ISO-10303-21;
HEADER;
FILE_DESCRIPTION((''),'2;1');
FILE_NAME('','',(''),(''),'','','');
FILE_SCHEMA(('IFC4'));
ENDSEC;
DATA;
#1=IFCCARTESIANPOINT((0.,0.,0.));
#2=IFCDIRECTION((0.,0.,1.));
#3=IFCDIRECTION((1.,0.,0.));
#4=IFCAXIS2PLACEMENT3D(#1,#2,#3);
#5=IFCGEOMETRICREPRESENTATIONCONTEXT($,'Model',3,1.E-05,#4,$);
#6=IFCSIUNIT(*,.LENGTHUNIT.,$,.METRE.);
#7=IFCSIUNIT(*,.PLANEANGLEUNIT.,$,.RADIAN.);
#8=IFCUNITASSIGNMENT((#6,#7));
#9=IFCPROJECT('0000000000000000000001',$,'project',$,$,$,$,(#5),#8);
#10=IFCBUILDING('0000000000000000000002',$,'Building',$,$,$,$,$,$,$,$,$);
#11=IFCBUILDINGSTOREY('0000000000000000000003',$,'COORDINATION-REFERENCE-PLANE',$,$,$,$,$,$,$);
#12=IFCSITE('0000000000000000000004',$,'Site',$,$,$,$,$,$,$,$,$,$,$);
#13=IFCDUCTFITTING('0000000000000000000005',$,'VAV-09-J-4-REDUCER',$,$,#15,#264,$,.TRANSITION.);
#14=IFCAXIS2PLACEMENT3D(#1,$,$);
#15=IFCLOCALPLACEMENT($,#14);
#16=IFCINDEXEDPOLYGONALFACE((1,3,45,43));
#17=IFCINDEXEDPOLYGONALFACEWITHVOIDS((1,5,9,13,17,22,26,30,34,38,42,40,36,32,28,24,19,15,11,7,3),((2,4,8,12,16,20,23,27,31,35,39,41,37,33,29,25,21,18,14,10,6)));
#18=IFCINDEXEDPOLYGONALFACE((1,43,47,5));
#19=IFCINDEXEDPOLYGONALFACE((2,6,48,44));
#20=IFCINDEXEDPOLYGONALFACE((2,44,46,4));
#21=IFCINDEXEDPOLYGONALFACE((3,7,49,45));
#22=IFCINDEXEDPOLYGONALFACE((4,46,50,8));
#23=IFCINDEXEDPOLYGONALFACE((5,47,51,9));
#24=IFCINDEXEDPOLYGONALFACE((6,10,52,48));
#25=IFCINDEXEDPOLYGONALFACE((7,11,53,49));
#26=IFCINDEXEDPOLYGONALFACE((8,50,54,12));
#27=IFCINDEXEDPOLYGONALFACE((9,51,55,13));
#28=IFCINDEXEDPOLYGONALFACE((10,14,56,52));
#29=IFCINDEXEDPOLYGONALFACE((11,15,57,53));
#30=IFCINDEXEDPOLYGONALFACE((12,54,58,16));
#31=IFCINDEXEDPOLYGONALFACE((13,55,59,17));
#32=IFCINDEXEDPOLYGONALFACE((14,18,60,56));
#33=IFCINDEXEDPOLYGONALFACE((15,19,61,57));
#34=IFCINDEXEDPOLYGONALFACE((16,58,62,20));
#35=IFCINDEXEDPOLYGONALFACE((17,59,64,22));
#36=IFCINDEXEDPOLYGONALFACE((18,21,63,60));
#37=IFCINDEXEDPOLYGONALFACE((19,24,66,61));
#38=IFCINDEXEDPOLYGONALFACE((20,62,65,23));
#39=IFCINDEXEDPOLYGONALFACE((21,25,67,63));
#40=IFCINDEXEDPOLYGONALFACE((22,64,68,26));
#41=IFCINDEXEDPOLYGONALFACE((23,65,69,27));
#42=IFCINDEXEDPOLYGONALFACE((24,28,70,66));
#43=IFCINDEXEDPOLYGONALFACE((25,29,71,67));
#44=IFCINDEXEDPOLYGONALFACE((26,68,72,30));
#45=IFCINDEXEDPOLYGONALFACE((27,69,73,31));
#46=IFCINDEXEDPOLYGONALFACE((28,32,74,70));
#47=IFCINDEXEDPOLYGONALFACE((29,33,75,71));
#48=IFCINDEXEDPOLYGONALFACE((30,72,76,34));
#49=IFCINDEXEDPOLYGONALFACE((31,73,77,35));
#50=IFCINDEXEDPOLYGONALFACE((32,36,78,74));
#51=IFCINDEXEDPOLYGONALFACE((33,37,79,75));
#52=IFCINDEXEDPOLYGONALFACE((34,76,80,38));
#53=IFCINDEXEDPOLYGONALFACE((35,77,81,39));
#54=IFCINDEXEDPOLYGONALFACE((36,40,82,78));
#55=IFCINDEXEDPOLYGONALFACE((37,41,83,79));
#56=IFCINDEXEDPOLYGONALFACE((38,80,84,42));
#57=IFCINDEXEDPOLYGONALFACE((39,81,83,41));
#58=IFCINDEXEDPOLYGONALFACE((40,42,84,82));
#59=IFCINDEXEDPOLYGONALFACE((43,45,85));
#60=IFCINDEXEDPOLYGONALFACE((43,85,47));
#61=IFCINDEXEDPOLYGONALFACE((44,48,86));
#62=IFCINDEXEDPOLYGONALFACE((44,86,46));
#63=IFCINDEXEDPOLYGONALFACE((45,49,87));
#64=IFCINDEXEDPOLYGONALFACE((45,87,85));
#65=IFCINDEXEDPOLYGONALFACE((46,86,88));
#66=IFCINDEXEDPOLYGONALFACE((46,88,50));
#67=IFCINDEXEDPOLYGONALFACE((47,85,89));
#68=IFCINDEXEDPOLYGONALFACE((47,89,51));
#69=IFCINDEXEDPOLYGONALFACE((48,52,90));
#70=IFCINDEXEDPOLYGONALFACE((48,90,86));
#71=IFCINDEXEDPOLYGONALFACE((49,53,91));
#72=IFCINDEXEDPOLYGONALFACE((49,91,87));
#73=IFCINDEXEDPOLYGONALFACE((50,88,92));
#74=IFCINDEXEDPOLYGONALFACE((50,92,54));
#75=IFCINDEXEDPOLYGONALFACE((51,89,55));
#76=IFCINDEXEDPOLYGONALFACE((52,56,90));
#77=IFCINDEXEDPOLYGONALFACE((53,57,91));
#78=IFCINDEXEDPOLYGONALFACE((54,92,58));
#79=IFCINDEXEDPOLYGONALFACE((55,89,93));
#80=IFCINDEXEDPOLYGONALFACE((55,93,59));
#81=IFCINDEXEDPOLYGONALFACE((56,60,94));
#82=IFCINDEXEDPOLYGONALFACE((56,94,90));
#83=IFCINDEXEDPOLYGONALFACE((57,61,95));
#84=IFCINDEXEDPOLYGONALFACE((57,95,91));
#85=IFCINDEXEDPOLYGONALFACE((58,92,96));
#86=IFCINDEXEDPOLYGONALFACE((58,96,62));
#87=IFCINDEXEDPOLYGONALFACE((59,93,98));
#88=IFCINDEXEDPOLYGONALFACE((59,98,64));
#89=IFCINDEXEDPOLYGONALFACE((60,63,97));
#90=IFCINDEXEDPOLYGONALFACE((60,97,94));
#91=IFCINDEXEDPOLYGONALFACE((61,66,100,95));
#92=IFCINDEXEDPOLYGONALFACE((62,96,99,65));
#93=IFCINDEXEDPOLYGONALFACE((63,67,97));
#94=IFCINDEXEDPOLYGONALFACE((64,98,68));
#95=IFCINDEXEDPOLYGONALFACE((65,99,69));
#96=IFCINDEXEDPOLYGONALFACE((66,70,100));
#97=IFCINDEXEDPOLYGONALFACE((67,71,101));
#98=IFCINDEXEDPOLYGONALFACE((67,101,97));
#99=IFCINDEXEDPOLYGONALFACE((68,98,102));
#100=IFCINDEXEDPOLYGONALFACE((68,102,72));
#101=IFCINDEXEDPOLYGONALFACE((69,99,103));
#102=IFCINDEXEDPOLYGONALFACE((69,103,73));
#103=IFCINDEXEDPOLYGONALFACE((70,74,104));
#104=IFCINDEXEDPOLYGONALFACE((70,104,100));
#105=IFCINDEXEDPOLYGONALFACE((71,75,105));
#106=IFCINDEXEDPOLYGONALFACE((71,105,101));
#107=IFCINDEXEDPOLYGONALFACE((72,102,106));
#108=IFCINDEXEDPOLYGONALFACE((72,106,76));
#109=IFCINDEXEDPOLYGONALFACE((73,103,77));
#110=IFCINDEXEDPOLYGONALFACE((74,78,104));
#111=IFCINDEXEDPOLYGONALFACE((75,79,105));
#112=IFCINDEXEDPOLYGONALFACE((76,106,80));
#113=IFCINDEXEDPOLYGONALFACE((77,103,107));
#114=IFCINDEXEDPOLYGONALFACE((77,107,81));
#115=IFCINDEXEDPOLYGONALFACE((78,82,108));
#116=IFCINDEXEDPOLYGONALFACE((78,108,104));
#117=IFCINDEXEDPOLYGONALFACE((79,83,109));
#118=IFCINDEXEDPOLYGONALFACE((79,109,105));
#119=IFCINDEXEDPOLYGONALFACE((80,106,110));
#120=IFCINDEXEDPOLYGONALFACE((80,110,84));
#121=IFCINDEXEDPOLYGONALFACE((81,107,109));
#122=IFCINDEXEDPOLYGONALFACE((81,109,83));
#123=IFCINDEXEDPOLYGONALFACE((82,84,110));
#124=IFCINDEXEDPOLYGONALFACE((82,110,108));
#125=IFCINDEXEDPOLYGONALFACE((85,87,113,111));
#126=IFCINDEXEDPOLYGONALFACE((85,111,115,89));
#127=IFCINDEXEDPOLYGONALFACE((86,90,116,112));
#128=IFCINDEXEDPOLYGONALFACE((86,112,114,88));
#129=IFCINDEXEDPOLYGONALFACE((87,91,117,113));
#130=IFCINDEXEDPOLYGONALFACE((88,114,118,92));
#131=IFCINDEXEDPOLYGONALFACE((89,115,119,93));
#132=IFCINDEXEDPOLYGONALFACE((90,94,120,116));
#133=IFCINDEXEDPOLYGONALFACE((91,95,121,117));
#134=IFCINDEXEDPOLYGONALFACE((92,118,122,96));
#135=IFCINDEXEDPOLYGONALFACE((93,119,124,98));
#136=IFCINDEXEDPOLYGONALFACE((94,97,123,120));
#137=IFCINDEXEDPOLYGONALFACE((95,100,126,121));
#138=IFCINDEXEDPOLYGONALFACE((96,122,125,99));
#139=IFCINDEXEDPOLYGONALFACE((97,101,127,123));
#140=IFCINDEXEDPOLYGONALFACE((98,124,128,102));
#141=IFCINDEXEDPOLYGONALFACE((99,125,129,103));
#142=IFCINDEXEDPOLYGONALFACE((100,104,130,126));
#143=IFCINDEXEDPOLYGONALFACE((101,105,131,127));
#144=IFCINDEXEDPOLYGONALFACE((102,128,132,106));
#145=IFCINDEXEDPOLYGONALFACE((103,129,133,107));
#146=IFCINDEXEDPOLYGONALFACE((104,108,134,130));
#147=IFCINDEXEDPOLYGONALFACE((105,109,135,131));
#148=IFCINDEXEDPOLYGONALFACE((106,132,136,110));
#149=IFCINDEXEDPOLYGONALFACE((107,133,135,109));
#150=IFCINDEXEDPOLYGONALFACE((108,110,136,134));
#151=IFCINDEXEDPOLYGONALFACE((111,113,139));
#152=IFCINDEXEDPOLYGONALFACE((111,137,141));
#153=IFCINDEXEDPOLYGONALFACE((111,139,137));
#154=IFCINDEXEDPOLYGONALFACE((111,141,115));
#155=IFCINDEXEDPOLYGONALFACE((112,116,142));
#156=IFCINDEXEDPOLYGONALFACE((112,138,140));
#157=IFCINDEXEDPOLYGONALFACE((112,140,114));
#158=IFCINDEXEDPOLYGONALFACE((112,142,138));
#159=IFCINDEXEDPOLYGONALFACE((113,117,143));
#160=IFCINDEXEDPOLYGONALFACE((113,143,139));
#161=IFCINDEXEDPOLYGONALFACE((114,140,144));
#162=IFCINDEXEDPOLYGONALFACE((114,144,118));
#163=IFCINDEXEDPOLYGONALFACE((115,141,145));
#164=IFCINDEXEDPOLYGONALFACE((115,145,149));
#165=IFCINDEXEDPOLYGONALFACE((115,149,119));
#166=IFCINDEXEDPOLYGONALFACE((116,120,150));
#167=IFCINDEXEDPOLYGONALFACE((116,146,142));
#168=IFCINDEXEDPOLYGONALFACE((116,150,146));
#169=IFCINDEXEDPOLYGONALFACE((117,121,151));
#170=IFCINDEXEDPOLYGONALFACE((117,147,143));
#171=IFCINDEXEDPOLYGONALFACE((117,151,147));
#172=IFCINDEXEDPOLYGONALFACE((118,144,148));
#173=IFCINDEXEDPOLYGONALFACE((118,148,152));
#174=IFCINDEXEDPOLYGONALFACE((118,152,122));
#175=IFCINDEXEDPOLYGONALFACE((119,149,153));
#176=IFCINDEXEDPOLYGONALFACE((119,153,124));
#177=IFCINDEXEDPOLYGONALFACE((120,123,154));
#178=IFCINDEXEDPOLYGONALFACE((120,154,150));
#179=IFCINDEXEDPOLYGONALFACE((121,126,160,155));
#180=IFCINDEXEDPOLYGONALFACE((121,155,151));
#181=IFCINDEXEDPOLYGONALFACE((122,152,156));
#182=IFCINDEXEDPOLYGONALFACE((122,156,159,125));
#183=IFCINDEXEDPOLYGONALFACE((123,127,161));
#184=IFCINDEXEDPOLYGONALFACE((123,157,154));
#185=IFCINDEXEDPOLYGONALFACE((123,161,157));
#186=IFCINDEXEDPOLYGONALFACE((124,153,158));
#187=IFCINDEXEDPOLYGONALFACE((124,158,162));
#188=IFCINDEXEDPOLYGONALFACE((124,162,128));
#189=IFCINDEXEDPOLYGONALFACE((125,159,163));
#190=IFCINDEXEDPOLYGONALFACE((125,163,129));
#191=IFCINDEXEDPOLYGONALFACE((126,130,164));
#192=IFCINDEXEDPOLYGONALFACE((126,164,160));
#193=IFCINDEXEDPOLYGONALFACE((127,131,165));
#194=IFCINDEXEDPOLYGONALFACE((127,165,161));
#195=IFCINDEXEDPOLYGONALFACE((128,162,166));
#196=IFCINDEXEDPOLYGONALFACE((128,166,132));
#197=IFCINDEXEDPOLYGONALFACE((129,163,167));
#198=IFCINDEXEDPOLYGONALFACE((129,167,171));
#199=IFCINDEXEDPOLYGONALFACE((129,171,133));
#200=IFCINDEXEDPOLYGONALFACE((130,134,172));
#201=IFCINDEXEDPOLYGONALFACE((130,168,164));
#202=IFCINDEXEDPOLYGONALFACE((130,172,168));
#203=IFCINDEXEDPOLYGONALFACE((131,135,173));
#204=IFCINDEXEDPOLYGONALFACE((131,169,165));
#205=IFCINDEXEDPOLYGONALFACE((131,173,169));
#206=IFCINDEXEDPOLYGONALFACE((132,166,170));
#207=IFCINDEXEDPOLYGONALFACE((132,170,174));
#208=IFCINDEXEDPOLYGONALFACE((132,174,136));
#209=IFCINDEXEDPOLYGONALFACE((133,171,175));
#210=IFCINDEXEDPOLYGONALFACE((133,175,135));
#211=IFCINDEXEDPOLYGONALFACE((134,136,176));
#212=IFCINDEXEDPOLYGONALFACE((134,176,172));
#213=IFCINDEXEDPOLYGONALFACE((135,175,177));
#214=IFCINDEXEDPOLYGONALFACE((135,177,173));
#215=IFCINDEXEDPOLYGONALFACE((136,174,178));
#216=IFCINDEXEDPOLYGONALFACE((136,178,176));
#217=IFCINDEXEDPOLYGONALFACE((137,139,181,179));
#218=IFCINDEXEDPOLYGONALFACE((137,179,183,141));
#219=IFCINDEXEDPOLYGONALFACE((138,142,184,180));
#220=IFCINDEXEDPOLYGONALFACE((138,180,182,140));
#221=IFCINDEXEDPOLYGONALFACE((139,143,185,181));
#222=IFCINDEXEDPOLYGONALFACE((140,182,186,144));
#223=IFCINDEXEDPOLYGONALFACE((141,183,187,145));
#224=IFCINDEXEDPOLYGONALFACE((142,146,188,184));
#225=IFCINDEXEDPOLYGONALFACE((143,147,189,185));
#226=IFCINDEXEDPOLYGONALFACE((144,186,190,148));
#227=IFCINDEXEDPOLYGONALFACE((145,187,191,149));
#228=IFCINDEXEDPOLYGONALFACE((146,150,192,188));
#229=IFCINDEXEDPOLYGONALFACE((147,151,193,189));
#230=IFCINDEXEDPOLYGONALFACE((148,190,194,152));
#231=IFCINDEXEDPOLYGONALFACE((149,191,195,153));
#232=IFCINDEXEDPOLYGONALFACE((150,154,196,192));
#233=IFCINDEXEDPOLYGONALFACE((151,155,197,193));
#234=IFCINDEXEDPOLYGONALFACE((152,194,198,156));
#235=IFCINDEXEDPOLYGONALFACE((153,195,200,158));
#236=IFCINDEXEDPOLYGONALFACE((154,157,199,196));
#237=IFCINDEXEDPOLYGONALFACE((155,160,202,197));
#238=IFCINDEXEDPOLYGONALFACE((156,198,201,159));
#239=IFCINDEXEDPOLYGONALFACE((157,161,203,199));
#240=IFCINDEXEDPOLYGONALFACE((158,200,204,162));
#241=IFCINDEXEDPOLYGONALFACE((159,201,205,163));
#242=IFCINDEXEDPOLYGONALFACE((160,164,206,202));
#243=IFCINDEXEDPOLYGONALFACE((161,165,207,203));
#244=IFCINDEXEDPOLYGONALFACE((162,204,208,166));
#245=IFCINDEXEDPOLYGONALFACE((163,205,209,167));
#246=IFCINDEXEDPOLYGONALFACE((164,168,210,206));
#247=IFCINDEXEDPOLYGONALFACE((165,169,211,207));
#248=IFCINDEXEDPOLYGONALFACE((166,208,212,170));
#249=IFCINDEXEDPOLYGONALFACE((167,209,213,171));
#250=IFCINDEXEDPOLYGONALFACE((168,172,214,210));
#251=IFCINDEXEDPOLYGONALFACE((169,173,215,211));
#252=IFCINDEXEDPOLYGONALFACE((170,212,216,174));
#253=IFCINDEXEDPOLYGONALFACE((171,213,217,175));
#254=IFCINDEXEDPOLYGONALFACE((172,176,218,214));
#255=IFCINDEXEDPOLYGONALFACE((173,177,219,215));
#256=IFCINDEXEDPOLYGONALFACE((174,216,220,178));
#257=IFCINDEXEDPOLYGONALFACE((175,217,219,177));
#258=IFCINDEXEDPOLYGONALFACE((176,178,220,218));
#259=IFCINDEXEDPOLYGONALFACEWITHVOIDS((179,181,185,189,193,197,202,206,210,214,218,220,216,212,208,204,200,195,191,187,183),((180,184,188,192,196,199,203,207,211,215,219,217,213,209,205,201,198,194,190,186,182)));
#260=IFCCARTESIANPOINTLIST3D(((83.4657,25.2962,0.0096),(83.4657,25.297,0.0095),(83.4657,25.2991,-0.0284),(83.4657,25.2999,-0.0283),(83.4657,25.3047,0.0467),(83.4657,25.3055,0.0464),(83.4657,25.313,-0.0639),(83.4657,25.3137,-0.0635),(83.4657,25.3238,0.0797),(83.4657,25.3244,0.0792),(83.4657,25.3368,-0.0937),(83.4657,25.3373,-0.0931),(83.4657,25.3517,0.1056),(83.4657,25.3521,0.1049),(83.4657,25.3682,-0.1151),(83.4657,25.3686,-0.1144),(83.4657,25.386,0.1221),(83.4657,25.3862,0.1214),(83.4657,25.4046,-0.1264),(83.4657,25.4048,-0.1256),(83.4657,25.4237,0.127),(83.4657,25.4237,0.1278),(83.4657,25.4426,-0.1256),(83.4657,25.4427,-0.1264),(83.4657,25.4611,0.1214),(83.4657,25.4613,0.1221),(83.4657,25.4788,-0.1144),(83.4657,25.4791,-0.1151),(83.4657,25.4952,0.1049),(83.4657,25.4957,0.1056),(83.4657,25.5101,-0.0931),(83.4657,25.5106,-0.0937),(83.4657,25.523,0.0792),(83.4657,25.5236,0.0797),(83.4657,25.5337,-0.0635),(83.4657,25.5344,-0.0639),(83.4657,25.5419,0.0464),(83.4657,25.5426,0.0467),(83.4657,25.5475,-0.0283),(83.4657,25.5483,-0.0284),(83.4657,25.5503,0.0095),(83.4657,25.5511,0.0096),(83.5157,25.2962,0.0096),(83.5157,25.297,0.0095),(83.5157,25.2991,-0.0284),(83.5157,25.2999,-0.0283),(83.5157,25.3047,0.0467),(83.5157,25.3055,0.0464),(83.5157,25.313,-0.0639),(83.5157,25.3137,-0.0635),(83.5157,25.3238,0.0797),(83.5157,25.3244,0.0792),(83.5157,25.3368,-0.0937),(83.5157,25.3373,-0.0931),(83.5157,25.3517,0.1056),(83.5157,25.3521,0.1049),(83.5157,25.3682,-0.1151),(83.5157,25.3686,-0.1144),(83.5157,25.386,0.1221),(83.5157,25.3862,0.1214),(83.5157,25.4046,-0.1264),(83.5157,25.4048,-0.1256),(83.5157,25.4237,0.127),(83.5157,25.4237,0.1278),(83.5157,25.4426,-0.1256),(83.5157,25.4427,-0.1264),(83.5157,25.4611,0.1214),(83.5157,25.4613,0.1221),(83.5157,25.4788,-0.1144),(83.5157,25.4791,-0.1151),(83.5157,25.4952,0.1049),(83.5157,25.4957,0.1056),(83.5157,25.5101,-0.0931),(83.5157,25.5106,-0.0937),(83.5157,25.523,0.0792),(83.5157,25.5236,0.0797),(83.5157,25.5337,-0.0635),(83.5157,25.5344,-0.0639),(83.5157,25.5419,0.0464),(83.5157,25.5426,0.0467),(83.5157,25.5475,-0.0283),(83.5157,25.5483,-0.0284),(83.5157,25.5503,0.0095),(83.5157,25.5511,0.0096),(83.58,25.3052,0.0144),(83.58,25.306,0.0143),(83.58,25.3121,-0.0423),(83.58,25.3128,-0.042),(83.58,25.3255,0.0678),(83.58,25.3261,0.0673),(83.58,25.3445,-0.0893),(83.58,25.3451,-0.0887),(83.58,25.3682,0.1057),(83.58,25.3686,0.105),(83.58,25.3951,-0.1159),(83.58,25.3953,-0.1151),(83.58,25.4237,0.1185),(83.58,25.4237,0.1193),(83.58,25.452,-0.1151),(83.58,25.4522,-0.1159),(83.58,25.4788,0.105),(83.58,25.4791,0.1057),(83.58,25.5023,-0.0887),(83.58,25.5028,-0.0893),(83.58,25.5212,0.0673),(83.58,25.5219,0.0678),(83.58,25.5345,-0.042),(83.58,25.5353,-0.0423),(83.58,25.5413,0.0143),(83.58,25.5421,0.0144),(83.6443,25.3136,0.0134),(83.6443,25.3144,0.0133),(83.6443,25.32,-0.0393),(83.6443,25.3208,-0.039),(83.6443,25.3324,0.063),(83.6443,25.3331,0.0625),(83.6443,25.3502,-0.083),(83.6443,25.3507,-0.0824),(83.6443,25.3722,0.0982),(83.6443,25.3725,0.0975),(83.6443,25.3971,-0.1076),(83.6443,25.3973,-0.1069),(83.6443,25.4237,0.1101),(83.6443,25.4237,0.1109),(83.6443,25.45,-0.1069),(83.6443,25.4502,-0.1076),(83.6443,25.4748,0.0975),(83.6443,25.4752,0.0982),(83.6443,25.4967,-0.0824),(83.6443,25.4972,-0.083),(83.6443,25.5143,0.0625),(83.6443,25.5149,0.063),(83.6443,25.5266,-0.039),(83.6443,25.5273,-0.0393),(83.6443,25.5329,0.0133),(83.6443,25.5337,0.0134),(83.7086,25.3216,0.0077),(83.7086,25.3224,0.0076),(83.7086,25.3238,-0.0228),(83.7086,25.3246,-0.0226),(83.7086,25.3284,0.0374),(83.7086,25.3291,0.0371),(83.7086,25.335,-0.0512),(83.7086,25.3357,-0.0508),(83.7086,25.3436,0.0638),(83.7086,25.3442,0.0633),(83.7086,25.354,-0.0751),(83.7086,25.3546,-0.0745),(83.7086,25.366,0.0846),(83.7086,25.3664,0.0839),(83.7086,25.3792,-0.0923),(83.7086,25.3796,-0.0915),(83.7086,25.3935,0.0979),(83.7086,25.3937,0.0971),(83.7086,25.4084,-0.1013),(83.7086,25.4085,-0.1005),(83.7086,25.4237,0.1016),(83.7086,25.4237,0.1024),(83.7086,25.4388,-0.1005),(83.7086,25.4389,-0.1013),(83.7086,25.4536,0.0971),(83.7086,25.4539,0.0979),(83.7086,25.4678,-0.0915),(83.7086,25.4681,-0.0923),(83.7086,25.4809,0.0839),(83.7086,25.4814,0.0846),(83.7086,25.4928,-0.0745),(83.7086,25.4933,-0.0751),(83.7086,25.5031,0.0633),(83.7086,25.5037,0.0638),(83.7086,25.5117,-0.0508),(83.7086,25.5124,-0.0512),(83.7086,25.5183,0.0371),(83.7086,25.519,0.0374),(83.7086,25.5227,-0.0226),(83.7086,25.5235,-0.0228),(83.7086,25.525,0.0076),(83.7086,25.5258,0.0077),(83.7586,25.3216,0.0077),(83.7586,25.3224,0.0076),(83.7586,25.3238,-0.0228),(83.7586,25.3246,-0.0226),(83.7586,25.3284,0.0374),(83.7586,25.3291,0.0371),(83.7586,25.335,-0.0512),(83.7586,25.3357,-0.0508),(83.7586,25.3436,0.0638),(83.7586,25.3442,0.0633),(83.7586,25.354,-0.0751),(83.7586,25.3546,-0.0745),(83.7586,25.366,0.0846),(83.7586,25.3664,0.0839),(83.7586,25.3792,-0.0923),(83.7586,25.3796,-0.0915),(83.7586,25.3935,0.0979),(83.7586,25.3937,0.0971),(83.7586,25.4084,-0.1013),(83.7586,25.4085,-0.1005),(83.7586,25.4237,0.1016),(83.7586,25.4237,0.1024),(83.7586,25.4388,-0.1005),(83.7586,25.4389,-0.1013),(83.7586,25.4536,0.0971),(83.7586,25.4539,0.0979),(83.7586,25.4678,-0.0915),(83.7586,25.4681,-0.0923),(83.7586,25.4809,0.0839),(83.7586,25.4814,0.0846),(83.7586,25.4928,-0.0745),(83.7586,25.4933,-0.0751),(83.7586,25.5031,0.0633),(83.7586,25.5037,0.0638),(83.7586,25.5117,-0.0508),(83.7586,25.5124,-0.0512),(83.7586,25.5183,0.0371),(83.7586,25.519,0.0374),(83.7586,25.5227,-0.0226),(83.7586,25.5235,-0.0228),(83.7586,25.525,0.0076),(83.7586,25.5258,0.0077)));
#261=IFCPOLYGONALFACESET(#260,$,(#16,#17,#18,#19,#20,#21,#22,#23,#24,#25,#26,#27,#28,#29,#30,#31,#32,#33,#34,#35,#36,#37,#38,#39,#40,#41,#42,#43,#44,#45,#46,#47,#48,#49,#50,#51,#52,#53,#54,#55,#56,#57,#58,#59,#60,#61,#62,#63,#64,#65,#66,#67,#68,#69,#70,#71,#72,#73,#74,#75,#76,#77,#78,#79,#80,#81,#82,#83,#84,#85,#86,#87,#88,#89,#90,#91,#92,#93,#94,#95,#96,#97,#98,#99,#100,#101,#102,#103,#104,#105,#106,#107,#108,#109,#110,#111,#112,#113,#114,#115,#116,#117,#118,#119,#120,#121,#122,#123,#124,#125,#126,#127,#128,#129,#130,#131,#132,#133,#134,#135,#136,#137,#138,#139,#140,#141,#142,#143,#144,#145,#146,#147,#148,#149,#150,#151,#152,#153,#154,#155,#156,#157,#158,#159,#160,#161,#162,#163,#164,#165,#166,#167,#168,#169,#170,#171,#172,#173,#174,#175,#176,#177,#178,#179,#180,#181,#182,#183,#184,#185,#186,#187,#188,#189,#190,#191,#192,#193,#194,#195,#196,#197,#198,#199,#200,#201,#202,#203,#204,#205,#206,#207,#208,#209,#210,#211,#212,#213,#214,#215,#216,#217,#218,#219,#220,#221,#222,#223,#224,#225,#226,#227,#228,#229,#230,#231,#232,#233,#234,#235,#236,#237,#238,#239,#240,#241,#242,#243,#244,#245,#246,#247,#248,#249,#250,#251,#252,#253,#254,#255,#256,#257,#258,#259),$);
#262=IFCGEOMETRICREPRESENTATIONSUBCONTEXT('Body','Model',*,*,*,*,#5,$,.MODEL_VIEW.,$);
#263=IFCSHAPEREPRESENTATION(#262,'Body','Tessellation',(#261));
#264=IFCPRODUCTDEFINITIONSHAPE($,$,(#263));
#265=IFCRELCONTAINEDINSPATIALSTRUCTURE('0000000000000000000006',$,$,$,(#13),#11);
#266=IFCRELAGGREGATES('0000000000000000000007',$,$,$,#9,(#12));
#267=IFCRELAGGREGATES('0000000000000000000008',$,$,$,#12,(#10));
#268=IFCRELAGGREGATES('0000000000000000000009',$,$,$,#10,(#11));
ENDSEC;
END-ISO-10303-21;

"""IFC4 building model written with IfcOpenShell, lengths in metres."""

from ifc_helpers import new_model, entity, si_unit, frame, origin_with_axes, place, context, subcontext, project, spatial, element, save


model = new_model("IFC4")

# Units and contexts
model_context = context("Model", 3, precision=1e-05, world=origin_with_axes())
body_context_1 = subcontext(model_context, "Body", "Model", "MODEL_VIEW")
ifc_project = project(units=[si_unit("LENGTHUNIT", "METRE"), si_unit("PLANEANGLEUNIT", "RADIAN")], contexts=[model_context])

# Site, building, storey
site = spatial("IfcSite", under=ifc_project, Name="Site")
building = spatial("IfcBuilding", under=site, Name="Building")
storey = spatial("IfcBuildingStorey", under=building, Name="COORDINATION-REFERENCE-PLANE")

# Duct fitting
for number, where, z_axis, x_axis, name in (
    (1, (83.4657, 25.4237, 0.0), (0.0, 1.0, 0.0), (0.0, 0.0, 1.0), "VAV-09-J-4-REDUCER"),
):
    element("IfcDuctFitting", number, at=place(None, frame(where, z_axis=z_axis, x_axis=x_axis)), inside=storey, Name=name, PredefinedType="TRANSITION", context=body_context_1, shape_type="SweptSolid", body=[
        entity("IfcRevolvedAreaSolid", entity("IfcArbitraryClosedProfileDef", "AREA", None, entity("IfcPolyline", [entity("IfcCartesianPoint", [0.1278, 0.0]), entity("IfcCartesianPoint", [0.1278, 0.05]), entity("IfcCartesianPoint", [0.1024, 0.2429]), entity("IfcCartesianPoint", [0.1024, 0.2929]), entity("IfcCartesianPoint", [0.1016, 0.2929]), entity("IfcCartesianPoint", [0.1016, 0.2429]), entity("IfcCartesianPoint", [0.127, 0.05]), entity("IfcCartesianPoint", [0.127, 0.0]), entity("IfcCartesianPoint", [0.1278, 0.0])])), entity("IfcAxis2Placement3D", entity("IfcCartesianPoint", [0.0, 0.0, 0.0])), entity("IfcAxis1Placement", entity("IfcCartesianPoint", [0.0, 0.0, 0.0]), entity("IfcDirection", [0.0, 1.0, 0.0])), 6.283185),
    ])

save(model, "model.ifc")
